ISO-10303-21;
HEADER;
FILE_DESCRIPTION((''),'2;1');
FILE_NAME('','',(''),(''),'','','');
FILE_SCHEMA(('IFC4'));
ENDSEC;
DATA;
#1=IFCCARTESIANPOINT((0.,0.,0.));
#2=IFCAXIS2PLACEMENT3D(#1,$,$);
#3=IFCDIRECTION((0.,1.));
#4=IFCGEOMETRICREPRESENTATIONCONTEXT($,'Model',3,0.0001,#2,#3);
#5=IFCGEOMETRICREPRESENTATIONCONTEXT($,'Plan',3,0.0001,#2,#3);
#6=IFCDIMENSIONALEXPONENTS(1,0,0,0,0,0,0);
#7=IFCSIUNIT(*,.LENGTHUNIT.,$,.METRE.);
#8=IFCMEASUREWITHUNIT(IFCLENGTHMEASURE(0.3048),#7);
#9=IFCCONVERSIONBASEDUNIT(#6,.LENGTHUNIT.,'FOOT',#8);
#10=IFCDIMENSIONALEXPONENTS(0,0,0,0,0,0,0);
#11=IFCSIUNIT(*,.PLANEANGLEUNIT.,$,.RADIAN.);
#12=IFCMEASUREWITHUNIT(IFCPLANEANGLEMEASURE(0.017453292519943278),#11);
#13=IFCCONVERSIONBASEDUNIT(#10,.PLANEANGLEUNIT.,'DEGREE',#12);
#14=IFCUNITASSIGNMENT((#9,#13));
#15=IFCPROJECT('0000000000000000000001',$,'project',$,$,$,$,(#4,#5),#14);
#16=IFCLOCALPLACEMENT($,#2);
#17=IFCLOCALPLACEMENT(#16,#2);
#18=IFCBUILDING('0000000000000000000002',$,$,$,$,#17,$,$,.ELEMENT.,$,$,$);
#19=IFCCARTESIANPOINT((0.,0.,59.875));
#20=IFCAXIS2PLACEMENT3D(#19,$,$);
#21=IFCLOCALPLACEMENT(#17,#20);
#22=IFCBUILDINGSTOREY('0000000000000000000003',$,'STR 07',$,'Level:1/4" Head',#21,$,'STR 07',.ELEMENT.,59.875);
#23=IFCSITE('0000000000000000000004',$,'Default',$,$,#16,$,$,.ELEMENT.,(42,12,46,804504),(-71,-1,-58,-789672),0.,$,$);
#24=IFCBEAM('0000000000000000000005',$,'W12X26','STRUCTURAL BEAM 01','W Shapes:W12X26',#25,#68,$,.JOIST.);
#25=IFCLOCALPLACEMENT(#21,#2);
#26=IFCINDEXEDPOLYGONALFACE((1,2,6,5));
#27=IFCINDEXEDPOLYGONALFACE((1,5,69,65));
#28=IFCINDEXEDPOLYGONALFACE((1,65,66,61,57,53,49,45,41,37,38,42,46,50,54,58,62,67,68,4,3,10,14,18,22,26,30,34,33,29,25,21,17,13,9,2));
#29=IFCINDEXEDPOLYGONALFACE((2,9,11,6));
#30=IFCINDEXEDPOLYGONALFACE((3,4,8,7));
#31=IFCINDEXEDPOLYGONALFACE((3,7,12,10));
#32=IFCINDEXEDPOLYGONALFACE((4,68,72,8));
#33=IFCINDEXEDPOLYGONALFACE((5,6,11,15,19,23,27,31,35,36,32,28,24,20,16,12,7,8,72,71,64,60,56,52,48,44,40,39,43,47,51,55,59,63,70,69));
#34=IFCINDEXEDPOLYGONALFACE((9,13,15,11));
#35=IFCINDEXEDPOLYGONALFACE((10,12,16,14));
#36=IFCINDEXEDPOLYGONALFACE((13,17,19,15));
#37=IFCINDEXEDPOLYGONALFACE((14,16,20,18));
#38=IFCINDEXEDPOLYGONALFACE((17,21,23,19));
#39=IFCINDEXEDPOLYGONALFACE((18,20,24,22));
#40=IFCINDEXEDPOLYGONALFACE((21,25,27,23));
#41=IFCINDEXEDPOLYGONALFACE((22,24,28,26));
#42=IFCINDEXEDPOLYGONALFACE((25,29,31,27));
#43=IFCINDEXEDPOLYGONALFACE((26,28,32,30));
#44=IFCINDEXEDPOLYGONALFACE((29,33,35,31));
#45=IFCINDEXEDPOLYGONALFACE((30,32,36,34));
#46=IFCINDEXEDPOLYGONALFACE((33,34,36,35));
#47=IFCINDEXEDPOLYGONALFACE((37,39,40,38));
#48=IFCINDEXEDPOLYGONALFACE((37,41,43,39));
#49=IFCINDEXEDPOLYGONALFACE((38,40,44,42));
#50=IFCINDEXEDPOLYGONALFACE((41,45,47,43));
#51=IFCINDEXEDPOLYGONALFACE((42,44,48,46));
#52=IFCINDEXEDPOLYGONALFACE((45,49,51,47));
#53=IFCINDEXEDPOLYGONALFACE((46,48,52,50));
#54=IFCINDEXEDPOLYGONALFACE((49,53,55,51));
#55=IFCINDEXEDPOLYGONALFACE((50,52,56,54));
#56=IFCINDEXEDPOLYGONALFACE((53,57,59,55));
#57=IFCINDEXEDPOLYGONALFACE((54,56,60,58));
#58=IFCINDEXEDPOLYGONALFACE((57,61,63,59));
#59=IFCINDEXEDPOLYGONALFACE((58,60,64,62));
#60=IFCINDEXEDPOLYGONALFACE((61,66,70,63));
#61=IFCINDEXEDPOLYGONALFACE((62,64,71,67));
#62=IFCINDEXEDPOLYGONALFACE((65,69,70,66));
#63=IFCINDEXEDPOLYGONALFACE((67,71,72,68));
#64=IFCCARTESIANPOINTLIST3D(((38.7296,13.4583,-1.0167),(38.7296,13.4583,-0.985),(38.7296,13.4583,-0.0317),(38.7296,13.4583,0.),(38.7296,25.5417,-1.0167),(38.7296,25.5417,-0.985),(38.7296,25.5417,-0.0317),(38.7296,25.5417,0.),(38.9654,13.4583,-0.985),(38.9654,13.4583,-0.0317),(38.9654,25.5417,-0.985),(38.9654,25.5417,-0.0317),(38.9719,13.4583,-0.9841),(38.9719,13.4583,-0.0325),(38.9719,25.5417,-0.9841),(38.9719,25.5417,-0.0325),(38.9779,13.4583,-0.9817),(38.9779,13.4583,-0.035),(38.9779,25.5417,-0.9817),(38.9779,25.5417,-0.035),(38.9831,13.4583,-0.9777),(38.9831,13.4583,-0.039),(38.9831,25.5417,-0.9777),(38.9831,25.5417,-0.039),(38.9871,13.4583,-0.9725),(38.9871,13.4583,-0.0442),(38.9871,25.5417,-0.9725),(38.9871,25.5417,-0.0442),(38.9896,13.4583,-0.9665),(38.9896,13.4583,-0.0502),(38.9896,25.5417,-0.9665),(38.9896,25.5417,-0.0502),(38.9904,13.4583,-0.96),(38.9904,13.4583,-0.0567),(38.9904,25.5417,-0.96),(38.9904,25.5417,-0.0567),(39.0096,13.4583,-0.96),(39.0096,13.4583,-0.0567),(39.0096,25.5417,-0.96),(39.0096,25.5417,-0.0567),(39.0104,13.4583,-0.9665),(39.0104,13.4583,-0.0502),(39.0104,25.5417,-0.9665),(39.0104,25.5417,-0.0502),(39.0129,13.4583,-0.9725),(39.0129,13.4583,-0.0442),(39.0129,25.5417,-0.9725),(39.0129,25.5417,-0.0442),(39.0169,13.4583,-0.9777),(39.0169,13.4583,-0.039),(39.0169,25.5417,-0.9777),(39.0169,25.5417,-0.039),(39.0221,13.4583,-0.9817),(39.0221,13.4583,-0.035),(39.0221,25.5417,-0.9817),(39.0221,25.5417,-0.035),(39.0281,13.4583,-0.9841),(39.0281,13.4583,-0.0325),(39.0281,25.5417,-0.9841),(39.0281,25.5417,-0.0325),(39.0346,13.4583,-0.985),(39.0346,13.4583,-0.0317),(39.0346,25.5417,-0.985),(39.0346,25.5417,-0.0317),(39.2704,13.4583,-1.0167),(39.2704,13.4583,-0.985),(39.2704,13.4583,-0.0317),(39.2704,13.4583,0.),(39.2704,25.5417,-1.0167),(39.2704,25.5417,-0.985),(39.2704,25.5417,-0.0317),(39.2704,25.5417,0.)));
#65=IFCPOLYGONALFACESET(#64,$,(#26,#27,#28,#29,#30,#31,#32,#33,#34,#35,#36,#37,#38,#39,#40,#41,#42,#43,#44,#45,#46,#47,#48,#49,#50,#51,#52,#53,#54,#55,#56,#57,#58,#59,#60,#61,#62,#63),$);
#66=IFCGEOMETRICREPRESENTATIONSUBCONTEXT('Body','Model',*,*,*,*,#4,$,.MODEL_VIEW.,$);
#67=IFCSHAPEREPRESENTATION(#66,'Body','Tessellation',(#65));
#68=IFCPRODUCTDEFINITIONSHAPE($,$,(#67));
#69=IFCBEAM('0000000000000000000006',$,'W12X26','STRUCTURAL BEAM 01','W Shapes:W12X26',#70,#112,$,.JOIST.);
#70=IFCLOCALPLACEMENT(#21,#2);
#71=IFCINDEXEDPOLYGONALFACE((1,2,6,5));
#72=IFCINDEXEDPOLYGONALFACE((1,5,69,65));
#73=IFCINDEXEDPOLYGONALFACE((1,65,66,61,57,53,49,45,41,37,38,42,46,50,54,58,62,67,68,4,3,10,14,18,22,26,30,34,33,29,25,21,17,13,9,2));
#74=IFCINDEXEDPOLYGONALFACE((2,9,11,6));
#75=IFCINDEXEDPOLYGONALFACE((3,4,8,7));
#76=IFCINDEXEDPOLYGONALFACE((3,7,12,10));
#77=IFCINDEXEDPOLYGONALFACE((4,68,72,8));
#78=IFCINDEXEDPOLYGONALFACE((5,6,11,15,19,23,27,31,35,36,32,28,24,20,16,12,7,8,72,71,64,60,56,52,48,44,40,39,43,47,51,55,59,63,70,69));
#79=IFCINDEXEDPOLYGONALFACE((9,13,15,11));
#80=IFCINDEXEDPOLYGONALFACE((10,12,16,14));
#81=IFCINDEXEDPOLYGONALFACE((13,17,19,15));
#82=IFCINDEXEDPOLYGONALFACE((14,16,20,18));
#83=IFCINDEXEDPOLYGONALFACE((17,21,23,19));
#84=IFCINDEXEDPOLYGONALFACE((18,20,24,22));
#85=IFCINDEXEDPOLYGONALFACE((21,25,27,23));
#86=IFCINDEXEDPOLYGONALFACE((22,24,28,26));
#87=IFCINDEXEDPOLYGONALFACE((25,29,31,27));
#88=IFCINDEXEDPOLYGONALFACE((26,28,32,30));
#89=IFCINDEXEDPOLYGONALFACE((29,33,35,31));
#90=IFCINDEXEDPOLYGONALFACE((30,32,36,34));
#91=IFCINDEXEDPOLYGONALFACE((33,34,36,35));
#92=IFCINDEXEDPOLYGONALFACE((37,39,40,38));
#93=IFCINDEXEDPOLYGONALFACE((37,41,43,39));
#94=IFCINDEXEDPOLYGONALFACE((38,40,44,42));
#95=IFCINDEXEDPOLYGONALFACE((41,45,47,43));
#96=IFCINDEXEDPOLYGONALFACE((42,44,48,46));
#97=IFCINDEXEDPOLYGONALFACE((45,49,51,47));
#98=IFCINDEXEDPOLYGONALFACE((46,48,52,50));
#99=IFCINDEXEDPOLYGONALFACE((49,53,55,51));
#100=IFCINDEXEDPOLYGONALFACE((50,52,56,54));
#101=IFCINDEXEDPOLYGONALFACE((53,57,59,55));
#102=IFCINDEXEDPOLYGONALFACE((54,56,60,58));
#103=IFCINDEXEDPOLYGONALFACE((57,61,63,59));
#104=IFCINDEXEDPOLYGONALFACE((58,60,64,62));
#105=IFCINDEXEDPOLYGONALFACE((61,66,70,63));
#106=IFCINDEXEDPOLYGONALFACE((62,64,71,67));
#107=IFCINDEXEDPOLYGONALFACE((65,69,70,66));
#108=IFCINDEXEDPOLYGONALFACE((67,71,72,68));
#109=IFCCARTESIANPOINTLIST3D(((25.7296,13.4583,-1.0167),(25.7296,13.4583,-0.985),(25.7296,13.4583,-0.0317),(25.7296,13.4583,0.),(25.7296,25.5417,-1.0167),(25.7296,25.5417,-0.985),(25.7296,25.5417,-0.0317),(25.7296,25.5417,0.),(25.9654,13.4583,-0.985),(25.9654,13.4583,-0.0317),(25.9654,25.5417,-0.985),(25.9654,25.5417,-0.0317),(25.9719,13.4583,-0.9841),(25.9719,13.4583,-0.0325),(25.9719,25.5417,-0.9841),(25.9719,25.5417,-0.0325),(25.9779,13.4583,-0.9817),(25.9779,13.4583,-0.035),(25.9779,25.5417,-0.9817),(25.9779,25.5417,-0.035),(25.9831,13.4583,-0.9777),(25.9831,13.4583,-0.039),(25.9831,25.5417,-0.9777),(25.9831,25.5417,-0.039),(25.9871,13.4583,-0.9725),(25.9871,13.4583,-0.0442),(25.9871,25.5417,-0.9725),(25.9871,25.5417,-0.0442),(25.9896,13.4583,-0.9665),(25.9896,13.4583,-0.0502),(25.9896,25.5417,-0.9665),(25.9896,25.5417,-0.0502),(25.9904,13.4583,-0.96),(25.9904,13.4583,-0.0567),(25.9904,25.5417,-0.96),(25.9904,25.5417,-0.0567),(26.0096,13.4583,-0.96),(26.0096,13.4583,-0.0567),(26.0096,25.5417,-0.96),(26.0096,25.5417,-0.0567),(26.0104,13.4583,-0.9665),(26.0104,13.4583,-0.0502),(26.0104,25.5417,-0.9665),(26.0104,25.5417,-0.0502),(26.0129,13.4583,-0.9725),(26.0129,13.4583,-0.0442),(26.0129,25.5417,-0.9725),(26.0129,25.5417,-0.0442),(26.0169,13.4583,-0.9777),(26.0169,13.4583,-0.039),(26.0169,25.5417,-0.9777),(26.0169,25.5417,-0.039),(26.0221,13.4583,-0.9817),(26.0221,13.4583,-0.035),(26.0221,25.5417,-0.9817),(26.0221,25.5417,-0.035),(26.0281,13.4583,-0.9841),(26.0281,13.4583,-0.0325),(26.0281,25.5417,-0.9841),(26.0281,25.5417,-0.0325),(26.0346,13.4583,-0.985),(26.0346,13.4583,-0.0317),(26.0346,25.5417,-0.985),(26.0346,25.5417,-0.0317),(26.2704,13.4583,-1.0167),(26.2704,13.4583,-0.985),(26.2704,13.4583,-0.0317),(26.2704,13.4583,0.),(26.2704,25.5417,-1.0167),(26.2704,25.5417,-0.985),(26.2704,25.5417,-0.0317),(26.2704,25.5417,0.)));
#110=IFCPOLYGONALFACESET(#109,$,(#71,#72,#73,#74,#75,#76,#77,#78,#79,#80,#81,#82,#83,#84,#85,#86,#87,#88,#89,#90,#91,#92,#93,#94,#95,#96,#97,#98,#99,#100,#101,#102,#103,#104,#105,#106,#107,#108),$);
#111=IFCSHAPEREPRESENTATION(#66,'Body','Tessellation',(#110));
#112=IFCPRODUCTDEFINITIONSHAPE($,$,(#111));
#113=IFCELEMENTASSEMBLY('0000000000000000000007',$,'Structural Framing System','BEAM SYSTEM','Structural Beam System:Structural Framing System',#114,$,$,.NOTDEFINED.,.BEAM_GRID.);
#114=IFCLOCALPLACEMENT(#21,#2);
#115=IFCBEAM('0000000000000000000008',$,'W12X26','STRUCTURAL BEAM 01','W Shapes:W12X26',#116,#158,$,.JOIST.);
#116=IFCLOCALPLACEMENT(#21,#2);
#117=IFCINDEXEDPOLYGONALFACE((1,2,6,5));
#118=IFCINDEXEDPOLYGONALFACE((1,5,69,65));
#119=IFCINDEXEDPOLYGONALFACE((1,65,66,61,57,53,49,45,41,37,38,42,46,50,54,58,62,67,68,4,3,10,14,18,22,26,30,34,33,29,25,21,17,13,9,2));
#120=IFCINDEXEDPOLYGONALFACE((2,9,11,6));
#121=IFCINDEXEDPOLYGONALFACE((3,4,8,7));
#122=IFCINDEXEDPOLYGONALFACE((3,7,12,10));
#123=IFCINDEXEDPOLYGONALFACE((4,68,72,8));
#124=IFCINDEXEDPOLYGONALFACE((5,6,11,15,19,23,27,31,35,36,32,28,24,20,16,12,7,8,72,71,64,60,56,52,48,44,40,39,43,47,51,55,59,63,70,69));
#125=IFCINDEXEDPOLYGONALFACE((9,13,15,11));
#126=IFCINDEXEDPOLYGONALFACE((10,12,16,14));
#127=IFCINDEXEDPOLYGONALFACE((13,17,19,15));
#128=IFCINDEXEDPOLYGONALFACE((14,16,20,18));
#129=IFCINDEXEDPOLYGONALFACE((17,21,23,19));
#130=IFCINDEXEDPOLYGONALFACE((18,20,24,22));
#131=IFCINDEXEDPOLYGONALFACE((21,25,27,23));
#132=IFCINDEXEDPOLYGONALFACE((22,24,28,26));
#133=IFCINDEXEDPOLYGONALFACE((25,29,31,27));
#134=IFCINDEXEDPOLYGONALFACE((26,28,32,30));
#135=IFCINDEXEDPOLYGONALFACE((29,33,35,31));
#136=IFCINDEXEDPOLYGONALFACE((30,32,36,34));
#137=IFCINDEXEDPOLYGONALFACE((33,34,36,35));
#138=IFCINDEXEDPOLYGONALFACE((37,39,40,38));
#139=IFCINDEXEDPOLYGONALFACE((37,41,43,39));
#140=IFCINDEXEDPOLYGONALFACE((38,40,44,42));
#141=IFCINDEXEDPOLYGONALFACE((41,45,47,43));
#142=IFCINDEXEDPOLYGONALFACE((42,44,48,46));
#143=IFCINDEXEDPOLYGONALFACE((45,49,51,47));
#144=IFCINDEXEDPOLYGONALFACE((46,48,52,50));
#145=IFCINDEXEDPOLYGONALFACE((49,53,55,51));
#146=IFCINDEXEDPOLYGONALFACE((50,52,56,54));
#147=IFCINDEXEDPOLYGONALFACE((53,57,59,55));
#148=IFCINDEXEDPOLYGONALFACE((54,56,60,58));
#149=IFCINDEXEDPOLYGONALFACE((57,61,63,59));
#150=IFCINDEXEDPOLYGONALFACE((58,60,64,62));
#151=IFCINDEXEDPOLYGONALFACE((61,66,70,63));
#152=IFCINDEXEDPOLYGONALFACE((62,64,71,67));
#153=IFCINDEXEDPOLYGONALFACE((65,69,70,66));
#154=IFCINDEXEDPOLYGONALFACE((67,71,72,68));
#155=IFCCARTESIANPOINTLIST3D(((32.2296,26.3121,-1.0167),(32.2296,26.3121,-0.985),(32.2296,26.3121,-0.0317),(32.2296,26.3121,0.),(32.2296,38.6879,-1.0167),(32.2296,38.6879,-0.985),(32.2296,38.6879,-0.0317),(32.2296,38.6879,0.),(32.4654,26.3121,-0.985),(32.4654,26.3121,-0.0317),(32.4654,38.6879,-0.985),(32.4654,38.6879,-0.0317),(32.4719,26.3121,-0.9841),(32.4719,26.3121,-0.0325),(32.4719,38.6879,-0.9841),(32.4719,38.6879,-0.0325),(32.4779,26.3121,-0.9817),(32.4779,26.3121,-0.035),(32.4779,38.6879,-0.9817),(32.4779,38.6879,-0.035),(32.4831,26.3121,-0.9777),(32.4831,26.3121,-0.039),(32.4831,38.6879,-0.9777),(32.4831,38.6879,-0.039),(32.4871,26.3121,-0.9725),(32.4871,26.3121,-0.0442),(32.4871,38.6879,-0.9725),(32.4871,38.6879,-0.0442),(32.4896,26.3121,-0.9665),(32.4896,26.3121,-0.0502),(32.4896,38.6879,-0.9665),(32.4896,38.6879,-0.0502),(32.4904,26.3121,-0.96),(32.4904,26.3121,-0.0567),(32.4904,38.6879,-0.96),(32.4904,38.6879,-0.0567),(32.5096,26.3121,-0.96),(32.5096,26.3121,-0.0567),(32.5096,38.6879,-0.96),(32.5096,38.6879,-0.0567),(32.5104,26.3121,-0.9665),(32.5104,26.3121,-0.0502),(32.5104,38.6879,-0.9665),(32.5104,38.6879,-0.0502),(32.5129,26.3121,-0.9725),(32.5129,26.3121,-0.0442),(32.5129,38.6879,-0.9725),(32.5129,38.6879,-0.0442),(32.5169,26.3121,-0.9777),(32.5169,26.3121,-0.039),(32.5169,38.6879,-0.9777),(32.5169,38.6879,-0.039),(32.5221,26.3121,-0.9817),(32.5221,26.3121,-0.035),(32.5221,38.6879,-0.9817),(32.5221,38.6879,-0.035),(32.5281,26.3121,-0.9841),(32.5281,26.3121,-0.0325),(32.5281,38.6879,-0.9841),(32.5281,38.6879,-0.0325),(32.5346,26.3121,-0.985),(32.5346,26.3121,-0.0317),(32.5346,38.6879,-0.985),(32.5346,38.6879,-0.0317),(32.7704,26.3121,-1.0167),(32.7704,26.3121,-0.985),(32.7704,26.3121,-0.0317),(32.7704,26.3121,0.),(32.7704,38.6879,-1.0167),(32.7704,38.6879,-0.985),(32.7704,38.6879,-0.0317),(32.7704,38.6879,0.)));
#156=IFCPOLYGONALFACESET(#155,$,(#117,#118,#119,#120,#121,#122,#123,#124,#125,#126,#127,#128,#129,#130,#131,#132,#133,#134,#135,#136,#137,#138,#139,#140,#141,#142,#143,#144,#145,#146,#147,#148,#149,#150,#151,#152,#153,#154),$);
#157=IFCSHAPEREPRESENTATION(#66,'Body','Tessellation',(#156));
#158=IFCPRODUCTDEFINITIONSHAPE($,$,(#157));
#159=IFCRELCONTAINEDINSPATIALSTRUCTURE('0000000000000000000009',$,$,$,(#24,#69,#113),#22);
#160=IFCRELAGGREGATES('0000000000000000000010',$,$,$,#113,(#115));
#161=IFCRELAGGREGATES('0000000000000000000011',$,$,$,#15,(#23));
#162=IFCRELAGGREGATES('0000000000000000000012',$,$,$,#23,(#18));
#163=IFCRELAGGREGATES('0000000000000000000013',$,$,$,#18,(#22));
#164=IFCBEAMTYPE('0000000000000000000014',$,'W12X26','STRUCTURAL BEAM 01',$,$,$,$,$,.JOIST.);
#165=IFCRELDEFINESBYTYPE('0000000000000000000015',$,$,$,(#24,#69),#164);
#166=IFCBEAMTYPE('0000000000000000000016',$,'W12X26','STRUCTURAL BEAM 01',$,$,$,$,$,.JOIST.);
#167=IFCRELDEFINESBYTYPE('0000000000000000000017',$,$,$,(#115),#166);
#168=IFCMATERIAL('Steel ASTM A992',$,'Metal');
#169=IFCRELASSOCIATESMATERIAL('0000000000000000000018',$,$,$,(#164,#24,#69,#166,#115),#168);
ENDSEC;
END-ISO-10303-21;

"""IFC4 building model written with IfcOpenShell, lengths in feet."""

from ifc_helpers import new_model, entity, si_unit, converted_unit, direction, frame, origin, place, context, subcontext, project, spatial, line, arc, indexed_curve, outline, extrude, source, transform, mapped, material, type_object, type_shapes, element, aggregate, save


model = new_model("IFC4")

# Units and contexts
model_context = context("Model", 3, precision=0.0001, world=origin(), true_north=direction((0.0, 1.0)))
plan_context = context("Plan", 3, precision=0.0001, world=origin(), true_north=direction((0.0, 1.0)))
body_context = subcontext(model_context, "Body", "Model", "MODEL_VIEW")
ifc_project = project(units=[converted_unit("LENGTHUNIT", "FOOT", entity("IfcLengthMeasure", 0.3048), si_unit("LENGTHUNIT", "METRE"), dimensions=[1, 0, 0, 0, 0, 0, 0]), converted_unit("PLANEANGLEUNIT", "DEGREE", entity("IfcPlaneAngleMeasure", 0.017453292519943278), si_unit("PLANEANGLEUNIT", "RADIAN"), dimensions=[0, 0, 0, 0, 0, 0, 0])], contexts=[model_context, plan_context])

# Site, building, storey
site_placement = place(None, origin())
site = spatial("IfcSite", under=ifc_project, at=site_placement, Name="Default", CompositionType="ELEMENT", RefLatitude=(42, 12, 46, 804504), RefLongitude=(-71, -1, -58, -789672), RefElevation=0.0)
building_placement = place(site_placement, origin())
building = spatial("IfcBuilding", under=site, at=building_placement, CompositionType="ELEMENT")
storey_placement = place(building_placement, frame((0.0, 0.0, 59.875)))
storey = spatial("IfcBuildingStorey", under=building, at=storey_placement, Name="STR 07", ObjectType="Level:1/4\" Head", LongName="STR 07", CompositionType="ELEMENT", Elevation=59.875)

# Beams
ifc_material = material(Name="Steel ASTM A992", Category="Metal")
beam_type_1 = type_object("IfcBeamType", Name="W12X26", Description="STRUCTURAL BEAM 01", PredefinedType="JOIST", material=ifc_material)
shared_shape_1 = source(origin(), body_context, "Body", "SweptSolid", [
    extrude(outline(indexed_curve([(-0.2704, -0.4767), (-0.2704, -0.5083), (0.2704, -0.5083), (0.2704, -0.4767), (0.0346, -0.4767), (0.0169, -0.4693), (0.0096, -0.4517), (0.0096, 0.4517), (0.0169, 0.4693), (0.0346, 0.4767), (0.2704, 0.4767), (0.2704, 0.5083), (-0.2704, 0.5083), (-0.2704, 0.4767), (-0.0346, 0.4767), (-0.0169, 0.4693), (-0.0096, 0.4517), (-0.0096, -0.4517), (-0.0169, -0.4693), (-0.0346, -0.4767)], segments=[line(1, 2, 3, 4, 5), arc(5, 6, 7), line(7, 8), arc(8, 9, 10), line(10, 11, 12, 13, 14, 15), arc(15, 16, 17), line(17, 18), arc(18, 19, 20), line(20, 1)], self_intersect=False)), frame((-6.2267, 0.0, 0.0), z_axis=(-1.0, 0.0, 0.0), x_axis=(0.0, -1.0, 0.0)), (0.0, 0.0, -1.0), 12.0833),
])
type_shapes(beam_type_1, [shared_shape_1])
for number, where, z_axis, x_axis, name in (
    (1, (39.0, 19.685, -0.5083), (0.0, 0.0, 1.0), (0.0, 1.0, 0.0), "W12X26"),
    (2, (26.0, 19.685, -0.5083), (0.0, 0.0, 1.0), (0.0, 1.0, 0.0), "W12X26"),
):
    element("IfcBeam", number, at=place(storey_placement, frame(where, z_axis=z_axis, x_axis=x_axis)), inside=storey, type_object=beam_type_1, material=ifc_material, Name=name, Description="STRUCTURAL BEAM 01", ObjectType="W Shapes:W12X26", PredefinedType="JOIST", context=body_context, shape_type="MappedRepresentation", body=[
        mapped(shared_shape_1, transform((0.0, 0.0, 0.0), scale=1.0)),
    ])

# Element assembly, beam
assembly_placement = place(storey_placement, origin())
assembly = element("IfcElementAssembly", 3, at=assembly_placement, inside=storey, Name="Structural Framing System", Description="BEAM SYSTEM", ObjectType="Structural Beam System:Structural Framing System", AssemblyPlace="NOTDEFINED", PredefinedType="BEAM_GRID")
beam_type_2 = type_object("IfcBeamType", Name="W12X26", Description="STRUCTURAL BEAM 01", PredefinedType="JOIST", material=ifc_material)
shared_shape_2 = source(origin(), body_context, "Body", "SweptSolid", [
    extrude(outline(indexed_curve([(-0.2704, -0.4767), (-0.2704, -0.5083), (0.2704, -0.5083), (0.2704, -0.4767), (0.0346, -0.4767), (0.0169, -0.4693), (0.0096, -0.4517), (0.0096, 0.4517), (0.0169, 0.4693), (0.0346, 0.4767), (0.2704, 0.4767), (0.2704, 0.5083), (-0.2704, 0.5083), (-0.2704, 0.4767), (-0.0346, 0.4767), (-0.0169, 0.4693), (-0.0096, 0.4517), (-0.0096, -0.4517), (-0.0169, -0.4693), (-0.0346, -0.4767)], segments=[line(1, 2, 3, 4, 5), arc(5, 6, 7), line(7, 8), arc(8, 9, 10), line(10, 11, 12, 13, 14, 15), arc(15, 16, 17), line(17, 18), arc(18, 19, 20), line(20, 1)], self_intersect=False)), frame((-6.1879, 0.0, 0.0), z_axis=(-1.0, 0.0, 0.0), x_axis=(0.0, -1.0, 0.0)), (0.0, 0.0, -1.0), 12.3758),
])
type_shapes(beam_type_2, [shared_shape_2])
beam_1_placement = place(assembly_placement, frame((32.5, 32.5, -0.5083), z_axis=(0.0, 0.0, 1.0), x_axis=(0.0, 1.0, 0.0)))
beam_1 = element("IfcBeam", 4, at=beam_1_placement, type_object=beam_type_2, material=ifc_material, Name="W12X26", Description="STRUCTURAL BEAM 01", ObjectType="W Shapes:W12X26", PredefinedType="JOIST", context=body_context, shape_type="MappedRepresentation", body=[
    mapped(shared_shape_2, transform((0.0, 0.0, 0.0), scale=1.0)),
])
aggregate(assembly, [beam_1])

save(model, "model.ifc")
